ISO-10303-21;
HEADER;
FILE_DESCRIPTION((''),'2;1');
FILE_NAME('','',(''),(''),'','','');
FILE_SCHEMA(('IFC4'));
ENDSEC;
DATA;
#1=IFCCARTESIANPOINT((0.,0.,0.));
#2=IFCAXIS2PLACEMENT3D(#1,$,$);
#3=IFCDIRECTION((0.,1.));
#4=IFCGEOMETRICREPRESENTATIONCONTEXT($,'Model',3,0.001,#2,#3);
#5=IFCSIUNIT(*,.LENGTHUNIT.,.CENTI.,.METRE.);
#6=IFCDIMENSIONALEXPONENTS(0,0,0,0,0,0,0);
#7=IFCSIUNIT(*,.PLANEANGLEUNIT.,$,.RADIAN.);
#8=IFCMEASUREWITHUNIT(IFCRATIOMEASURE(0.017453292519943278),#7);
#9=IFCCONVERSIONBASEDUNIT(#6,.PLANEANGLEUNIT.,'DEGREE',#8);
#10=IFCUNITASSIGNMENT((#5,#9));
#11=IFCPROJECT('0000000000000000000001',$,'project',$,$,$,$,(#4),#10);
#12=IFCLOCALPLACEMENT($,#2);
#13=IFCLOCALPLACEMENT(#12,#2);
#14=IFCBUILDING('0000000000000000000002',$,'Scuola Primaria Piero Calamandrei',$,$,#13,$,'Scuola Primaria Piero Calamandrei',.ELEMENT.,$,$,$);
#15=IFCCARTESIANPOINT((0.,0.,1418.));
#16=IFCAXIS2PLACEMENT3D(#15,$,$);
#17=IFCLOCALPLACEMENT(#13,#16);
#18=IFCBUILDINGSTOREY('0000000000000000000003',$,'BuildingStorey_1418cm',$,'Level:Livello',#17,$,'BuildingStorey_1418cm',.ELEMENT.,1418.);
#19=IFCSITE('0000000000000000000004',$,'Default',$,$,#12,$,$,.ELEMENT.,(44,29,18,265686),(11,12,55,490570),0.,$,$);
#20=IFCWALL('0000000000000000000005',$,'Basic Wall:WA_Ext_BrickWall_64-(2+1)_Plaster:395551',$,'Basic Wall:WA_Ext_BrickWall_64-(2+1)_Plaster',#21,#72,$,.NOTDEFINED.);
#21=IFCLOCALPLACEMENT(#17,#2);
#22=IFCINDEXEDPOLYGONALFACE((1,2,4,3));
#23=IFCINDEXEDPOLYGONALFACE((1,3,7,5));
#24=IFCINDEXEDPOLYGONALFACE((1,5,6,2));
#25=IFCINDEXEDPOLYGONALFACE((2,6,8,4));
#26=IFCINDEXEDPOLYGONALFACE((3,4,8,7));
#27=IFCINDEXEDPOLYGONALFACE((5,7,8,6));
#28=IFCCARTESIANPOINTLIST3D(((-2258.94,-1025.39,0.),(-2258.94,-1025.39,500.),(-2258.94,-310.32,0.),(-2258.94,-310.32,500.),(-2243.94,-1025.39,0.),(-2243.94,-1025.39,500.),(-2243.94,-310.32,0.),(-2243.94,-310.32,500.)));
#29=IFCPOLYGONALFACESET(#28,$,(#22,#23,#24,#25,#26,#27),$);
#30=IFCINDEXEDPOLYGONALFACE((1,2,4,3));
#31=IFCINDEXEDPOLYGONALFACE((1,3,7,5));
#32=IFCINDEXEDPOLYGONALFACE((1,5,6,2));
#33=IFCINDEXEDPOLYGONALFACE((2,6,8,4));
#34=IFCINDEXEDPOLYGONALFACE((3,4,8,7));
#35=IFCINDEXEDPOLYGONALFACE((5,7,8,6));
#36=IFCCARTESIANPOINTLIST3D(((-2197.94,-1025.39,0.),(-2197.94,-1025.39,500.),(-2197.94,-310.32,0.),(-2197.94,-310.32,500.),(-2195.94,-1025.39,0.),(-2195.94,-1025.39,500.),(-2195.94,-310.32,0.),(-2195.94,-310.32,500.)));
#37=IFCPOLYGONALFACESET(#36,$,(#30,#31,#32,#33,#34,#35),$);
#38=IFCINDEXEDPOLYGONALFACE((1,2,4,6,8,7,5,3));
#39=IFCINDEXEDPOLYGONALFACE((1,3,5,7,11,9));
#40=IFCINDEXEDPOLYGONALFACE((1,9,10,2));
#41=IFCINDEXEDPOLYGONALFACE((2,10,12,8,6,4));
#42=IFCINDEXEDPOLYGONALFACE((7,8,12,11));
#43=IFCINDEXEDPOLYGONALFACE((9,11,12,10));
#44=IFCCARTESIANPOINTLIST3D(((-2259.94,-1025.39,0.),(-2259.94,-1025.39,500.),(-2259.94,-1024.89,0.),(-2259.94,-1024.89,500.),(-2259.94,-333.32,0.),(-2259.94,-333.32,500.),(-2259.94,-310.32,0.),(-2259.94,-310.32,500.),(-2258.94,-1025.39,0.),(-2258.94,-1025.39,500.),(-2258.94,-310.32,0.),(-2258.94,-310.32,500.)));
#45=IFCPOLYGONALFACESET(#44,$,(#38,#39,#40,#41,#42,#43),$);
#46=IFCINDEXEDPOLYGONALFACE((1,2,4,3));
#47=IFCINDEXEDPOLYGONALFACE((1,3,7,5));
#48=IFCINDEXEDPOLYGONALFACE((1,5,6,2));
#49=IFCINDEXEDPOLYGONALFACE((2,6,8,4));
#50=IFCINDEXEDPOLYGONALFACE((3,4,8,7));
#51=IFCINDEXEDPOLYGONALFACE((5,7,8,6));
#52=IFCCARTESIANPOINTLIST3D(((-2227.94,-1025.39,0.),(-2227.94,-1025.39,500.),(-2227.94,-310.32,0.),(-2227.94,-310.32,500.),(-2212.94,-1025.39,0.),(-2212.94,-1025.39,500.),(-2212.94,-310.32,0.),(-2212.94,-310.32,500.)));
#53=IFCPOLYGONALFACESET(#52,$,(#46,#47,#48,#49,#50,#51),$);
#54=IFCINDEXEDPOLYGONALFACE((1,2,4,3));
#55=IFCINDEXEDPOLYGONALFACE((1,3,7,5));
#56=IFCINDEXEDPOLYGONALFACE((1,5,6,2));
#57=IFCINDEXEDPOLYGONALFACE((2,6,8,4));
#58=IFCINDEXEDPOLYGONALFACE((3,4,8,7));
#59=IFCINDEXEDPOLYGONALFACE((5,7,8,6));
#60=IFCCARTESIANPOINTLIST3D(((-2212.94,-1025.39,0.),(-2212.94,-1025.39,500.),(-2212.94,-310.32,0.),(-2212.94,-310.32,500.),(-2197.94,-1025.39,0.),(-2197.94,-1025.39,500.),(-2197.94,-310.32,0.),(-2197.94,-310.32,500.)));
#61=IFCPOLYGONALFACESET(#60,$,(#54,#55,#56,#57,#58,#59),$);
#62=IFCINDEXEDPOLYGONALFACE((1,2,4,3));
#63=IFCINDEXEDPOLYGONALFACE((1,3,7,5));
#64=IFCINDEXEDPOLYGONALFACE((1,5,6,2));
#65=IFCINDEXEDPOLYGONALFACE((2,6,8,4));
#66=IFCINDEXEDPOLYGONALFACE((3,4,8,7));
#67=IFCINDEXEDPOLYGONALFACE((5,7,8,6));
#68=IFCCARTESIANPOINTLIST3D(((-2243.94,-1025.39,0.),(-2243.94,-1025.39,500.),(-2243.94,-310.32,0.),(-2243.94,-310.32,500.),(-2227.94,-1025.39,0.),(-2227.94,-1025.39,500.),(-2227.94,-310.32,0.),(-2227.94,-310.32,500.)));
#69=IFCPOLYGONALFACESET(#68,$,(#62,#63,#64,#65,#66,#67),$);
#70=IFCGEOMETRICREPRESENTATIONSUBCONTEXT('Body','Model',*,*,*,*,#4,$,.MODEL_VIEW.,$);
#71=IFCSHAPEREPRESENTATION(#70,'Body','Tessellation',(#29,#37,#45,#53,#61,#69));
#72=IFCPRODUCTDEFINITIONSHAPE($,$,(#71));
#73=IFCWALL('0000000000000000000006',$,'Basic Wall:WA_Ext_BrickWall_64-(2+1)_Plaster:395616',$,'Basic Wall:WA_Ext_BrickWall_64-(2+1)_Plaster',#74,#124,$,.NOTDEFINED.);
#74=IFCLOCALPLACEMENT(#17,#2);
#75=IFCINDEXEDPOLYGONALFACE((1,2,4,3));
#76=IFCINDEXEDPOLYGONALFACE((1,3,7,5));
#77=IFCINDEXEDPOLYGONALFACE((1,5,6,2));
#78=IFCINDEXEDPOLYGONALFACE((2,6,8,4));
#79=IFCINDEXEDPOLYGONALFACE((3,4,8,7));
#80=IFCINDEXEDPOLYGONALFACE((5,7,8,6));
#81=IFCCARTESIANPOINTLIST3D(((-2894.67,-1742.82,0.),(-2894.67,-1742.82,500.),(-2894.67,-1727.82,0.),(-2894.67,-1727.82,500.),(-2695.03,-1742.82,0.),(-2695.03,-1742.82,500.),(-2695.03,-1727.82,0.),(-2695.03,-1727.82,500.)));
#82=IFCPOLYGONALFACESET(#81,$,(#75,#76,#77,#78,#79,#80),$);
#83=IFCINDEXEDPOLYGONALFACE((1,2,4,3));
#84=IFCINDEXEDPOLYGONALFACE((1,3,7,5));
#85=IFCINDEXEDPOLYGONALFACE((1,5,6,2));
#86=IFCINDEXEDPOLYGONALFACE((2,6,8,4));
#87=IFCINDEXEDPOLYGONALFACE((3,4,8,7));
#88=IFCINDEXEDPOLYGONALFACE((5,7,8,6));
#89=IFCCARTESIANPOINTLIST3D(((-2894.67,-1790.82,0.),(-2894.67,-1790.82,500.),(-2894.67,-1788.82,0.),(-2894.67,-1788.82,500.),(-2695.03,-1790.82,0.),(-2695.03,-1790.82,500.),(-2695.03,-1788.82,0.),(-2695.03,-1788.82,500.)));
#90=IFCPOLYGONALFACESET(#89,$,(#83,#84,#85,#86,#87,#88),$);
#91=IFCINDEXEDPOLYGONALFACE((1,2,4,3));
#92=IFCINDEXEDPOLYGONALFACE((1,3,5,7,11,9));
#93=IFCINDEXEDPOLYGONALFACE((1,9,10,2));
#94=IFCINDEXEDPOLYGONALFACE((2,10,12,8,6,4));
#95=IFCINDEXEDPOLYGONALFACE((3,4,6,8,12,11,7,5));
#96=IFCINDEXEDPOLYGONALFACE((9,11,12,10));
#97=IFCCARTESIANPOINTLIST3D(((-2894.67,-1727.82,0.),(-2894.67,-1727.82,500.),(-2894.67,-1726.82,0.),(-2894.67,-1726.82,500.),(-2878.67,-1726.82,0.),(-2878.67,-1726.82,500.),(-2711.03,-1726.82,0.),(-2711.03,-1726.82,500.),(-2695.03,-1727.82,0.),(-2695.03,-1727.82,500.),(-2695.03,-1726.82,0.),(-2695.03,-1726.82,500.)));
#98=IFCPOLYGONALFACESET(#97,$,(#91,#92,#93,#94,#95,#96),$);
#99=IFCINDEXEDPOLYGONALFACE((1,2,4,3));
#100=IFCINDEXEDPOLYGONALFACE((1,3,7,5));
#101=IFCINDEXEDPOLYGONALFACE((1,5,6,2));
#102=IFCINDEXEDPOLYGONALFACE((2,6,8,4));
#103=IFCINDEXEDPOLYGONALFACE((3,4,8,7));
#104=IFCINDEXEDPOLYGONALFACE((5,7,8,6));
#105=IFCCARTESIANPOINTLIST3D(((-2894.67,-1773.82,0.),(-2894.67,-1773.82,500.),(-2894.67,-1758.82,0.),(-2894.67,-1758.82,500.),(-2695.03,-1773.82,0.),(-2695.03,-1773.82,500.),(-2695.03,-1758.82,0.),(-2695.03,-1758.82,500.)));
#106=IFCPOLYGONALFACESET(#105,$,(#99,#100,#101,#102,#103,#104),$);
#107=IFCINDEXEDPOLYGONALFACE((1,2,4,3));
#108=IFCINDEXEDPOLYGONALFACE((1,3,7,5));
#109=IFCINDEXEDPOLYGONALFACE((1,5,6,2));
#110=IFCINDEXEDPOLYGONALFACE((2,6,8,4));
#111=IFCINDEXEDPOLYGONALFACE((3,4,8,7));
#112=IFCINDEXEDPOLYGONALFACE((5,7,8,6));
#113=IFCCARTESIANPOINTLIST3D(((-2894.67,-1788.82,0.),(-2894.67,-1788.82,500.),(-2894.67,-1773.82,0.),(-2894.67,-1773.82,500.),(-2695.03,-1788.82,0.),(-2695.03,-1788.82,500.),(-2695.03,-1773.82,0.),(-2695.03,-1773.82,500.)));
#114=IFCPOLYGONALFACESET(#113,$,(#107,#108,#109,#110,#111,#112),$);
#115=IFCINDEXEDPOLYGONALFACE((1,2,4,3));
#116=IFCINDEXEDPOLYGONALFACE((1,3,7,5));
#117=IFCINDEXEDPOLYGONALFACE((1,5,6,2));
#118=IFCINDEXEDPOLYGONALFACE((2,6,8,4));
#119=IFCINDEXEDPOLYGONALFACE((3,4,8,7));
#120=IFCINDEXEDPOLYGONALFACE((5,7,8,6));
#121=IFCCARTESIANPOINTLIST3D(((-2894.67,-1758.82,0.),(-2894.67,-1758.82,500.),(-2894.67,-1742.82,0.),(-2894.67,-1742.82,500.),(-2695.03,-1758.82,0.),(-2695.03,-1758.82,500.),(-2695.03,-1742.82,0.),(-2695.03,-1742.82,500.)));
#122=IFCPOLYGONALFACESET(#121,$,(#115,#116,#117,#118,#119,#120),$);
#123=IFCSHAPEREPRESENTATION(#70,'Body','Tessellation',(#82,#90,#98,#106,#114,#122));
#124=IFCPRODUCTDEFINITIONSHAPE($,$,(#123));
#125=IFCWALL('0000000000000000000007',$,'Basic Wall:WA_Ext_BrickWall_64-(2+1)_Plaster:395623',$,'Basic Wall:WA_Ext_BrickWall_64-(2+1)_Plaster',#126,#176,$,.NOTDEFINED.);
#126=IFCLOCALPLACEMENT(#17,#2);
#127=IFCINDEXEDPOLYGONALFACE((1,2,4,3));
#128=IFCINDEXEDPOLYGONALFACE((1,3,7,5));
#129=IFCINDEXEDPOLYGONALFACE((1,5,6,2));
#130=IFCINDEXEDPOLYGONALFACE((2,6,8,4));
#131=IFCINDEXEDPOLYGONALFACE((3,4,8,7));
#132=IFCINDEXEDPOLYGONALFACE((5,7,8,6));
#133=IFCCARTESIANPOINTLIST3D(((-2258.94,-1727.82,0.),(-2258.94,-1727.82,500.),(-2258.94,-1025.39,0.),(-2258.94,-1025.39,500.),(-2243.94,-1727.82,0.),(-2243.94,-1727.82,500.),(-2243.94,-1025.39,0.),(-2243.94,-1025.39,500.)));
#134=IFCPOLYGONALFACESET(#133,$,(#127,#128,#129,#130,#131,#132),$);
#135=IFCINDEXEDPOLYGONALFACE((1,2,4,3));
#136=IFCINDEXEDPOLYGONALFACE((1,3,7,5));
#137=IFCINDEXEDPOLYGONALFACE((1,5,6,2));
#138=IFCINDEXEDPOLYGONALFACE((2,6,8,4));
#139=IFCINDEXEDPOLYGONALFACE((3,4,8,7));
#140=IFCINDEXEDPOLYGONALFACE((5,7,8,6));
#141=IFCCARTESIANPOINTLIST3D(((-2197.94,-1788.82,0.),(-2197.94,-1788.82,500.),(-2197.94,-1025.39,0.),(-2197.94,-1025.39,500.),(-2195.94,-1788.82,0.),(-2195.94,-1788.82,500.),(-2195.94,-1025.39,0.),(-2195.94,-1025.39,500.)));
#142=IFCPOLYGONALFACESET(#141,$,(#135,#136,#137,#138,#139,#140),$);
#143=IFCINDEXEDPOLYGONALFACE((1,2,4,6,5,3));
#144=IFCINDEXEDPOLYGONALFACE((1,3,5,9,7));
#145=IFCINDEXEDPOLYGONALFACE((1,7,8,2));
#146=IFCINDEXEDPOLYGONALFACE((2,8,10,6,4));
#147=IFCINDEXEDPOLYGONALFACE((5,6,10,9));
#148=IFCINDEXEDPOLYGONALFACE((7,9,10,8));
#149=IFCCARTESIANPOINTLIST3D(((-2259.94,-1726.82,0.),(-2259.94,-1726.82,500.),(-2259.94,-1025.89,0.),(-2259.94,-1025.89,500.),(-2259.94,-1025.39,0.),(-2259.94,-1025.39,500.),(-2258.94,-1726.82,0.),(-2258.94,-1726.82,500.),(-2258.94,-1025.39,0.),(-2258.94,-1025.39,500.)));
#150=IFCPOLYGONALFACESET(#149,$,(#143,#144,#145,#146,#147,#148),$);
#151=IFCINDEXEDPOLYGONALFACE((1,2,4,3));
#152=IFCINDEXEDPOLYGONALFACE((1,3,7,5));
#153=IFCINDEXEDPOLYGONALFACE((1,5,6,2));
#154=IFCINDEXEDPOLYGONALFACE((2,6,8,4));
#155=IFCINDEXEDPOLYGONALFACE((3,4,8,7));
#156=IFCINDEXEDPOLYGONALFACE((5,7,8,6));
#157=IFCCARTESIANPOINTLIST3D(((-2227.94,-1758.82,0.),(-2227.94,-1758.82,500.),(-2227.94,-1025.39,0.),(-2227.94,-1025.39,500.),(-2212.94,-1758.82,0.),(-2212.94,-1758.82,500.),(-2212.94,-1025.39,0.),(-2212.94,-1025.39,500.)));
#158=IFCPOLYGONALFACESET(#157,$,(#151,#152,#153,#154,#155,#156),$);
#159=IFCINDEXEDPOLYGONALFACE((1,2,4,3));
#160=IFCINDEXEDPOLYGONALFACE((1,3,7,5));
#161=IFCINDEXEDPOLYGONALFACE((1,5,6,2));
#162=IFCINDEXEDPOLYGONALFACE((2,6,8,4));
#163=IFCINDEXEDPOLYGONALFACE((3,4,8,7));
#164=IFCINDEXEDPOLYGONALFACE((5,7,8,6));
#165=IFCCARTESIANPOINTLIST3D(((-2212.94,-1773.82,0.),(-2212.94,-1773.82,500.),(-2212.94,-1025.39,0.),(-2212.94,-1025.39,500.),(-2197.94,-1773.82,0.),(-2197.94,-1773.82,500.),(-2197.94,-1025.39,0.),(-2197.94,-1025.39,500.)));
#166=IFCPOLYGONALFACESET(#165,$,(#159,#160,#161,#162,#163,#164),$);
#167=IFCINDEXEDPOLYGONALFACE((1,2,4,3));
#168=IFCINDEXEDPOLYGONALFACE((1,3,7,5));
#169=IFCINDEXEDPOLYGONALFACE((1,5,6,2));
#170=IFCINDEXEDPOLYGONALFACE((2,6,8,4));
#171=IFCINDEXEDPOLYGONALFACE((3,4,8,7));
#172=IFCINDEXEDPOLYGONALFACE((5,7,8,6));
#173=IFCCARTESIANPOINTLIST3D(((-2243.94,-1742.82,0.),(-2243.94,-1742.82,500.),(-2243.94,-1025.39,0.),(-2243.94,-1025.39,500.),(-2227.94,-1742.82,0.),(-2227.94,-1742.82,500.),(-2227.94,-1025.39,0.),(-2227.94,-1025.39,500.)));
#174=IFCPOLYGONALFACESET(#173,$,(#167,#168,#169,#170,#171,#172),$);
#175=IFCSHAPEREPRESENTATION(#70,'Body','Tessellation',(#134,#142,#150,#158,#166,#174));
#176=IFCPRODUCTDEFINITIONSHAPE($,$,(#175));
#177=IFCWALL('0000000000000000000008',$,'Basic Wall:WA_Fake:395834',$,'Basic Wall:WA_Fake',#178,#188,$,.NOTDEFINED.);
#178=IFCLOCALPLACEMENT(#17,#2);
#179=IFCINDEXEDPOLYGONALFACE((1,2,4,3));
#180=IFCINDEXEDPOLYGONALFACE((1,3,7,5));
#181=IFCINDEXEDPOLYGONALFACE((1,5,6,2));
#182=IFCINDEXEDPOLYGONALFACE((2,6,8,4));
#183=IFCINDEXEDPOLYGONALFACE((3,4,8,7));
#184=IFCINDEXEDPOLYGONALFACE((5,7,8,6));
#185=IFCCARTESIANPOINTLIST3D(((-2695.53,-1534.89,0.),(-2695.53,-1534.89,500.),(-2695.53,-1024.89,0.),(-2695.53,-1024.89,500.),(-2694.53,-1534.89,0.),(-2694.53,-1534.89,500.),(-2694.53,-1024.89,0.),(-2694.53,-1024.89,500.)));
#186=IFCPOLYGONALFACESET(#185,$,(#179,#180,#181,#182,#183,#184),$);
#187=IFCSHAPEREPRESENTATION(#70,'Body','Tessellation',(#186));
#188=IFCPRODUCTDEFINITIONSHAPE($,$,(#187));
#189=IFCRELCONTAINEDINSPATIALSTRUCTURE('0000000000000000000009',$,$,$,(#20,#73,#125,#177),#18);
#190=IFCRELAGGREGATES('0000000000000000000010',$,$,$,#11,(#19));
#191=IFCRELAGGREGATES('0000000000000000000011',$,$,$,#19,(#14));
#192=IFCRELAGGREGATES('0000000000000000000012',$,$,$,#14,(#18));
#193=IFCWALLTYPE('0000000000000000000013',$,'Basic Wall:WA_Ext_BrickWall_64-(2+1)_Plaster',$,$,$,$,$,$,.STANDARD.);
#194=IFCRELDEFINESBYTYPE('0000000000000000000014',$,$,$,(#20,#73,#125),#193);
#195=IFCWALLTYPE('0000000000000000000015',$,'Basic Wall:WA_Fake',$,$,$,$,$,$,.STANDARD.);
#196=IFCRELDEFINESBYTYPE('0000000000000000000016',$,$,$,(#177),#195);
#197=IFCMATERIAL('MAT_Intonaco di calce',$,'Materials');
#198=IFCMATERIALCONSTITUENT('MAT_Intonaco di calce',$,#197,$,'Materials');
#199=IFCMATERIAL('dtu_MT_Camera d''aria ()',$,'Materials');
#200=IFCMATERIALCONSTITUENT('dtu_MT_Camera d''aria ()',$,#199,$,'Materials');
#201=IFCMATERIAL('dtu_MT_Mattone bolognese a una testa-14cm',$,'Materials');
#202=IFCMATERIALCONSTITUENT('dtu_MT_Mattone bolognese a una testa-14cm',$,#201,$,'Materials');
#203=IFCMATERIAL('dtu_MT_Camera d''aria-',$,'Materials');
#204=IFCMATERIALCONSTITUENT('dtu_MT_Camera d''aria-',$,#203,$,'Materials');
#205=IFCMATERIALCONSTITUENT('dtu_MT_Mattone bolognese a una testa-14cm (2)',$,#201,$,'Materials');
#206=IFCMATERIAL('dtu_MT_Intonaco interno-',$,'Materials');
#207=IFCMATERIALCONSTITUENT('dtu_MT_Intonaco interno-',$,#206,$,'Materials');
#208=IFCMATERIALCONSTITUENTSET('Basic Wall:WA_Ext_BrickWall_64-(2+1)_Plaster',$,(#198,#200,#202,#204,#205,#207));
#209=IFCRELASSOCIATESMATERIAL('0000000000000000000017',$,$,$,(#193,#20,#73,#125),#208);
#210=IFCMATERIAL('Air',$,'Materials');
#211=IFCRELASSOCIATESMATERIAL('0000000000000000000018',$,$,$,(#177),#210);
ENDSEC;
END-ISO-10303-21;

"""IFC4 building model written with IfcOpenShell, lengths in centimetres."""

from ifc_helpers import new_model, entity, si_unit, converted_unit, direction, frame, origin, place, context, subcontext, project, spatial, indexed_curve, outline, extrude, material, constituent, constituent_set, type_object, element, save


model = new_model("IFC4")

# Units and contexts
model_context = context("Model", 3, precision=0.001, world=origin(), true_north=direction((0.0, 1.0)))
body_context = subcontext(model_context, "Body", "Model", "MODEL_VIEW")
ifc_project = project(units=[si_unit("LENGTHUNIT", "METRE", prefix="CENTI"), converted_unit("PLANEANGLEUNIT", "DEGREE", entity("IfcRatioMeasure", 0.017453292519943278), si_unit("PLANEANGLEUNIT", "RADIAN"), dimensions=[0, 0, 0, 0, 0, 0, 0])], contexts=[model_context])

# Site, building, storey
site_placement = place(None, origin())
site = spatial("IfcSite", under=ifc_project, at=site_placement, Name="Default", CompositionType="ELEMENT", RefLatitude=(44, 29, 18, 265686), RefLongitude=(11, 12, 55, 490570), RefElevation=0.0)
building_placement = place(site_placement, origin())
building = spatial("IfcBuilding", under=site, at=building_placement, Name="Scuola Primaria Piero Calamandrei", LongName="Scuola Primaria Piero Calamandrei", CompositionType="ELEMENT")
storey_placement = place(building_placement, frame((0.0, 0.0, 1418.0)))
storey = spatial("IfcBuildingStorey", under=building, at=storey_placement, Name="BuildingStorey_1418cm", ObjectType="Level:Livello", LongName="BuildingStorey_1418cm", CompositionType="ELEMENT", Elevation=1418.0)

# Shared definitions
ifc_material_1 = material(Name="dtu_MT_Intonaco interno-", Category="Materials")

# Walls
ifc_material_2 = material(Name="MAT_Intonaco di calce", Category="Materials")
ifc_constituent_1 = constituent(ifc_material_2, Name="MAT_Intonaco di calce", Category="Materials")
ifc_material_3 = material(Name="dtu_MT_Camera d'aria ()", Category="Materials")
ifc_constituent_2 = constituent(ifc_material_3, Name="dtu_MT_Camera d'aria ()", Category="Materials")
ifc_material_4 = material(Name="dtu_MT_Mattone bolognese a una testa-14cm", Category="Materials")
ifc_constituent_3 = constituent(ifc_material_4, Name="dtu_MT_Mattone bolognese a una testa-14cm", Category="Materials")
ifc_material_5 = material(Name="dtu_MT_Camera d'aria-", Category="Materials")
ifc_constituent_4 = constituent(ifc_material_5, Name="dtu_MT_Camera d'aria-", Category="Materials")
ifc_constituent_5 = constituent(ifc_material_4, Name="dtu_MT_Mattone bolognese a una testa-14cm (2)", Category="Materials")
ifc_constituent_6 = constituent(ifc_material_1, Name="dtu_MT_Intonaco interno-", Category="Materials")
ifc_constituent_set_1 = constituent_set(constituents=[ifc_constituent_1, ifc_constituent_2, ifc_constituent_3, ifc_constituent_4, ifc_constituent_5, ifc_constituent_6], Name="Basic Wall:WA_Ext_BrickWall_64-(2+1)_Plaster")
wall_type_1 = type_object("IfcWallType", Name="Basic Wall:WA_Ext_BrickWall_64-(2+1)_Plaster", PredefinedType="STANDARD", material=ifc_constituent_set_1)
wall_1_placement = place(storey_placement, frame((-2227.94, -310.32, 0.0), z_axis=(0.0, 0.0, 1.0), x_axis=(0.0, -1.0, 0.0)))
element("IfcWall", 1, at=wall_1_placement, inside=storey, type_object=wall_type_1, material=ifc_constituent_set_1, Name="Basic Wall:WA_Ext_BrickWall_64-(2+1)_Plaster:395551", ObjectType="Basic Wall:WA_Ext_BrickWall_64-(2+1)_Plaster", PredefinedType="NOTDEFINED", context=body_context, shape_type="SweptSolid", body=[
    extrude(outline(indexed_curve([(-357.54, -7.5), (357.54, -7.5), (357.54, 7.5), (-357.54, 7.5), (-357.54, -7.5)], self_intersect=False)), frame((357.54, -23.5, 0.0)), (0.0, 0.0, 1.0), 500.0),
    extrude(outline(indexed_curve([(-1.0, -357.54), (1.0, -357.54), (1.0, 357.54), (-1.0, 357.54), (-1.0, -357.54)], self_intersect=False)), frame((357.54, 31.0, 0.0), z_axis=(0.0, 0.0, 1.0), x_axis=(0.0, -1.0, 0.0)), (0.0, 0.0, 1.0), 500.0),
    extrude(outline(indexed_curve([(-338.29, -0.33), (353.29, -0.33), (353.79, -0.33), (353.79, 0.67), (-361.29, 0.67), (-361.29, -0.33), (-338.29, -0.33)], self_intersect=False)), frame((361.29, -31.67, 0.0)), (0.0, 0.0, 1.0), 500.0),
    extrude(outline(indexed_curve([(-357.54, -7.5), (357.54, -7.5), (357.54, 7.5), (-357.54, 7.5), (-357.54, -7.5)], self_intersect=False)), frame((357.54, 7.5, 0.0)), (0.0, 0.0, 1.0), 500.0),
    extrude(outline(indexed_curve([(-357.54, -7.5), (357.54, -7.5), (357.54, 7.5), (-357.54, 7.5), (-357.54, -7.5)], self_intersect=False)), frame((357.54, 22.5, 0.0)), (0.0, 0.0, 1.0), 500.0),
    extrude(outline(indexed_curve([(-357.54, -8.0), (357.54, -8.0), (357.54, 8.0), (-357.54, 8.0), (-357.54, -8.0)], self_intersect=False)), frame((357.54, -8.0, 0.0)), (0.0, 0.0, 1.0), 500.0),
])
wall_2_placement = place(storey_placement, frame((-2695.03, -1758.82, 0.0), z_axis=(0.0, 0.0, 1.0), x_axis=(-1.0, 0.0, 0.0)))
element("IfcWall", 2, at=wall_2_placement, inside=storey, type_object=wall_type_1, material=ifc_constituent_set_1, Name="Basic Wall:WA_Ext_BrickWall_64-(2+1)_Plaster:395616", ObjectType="Basic Wall:WA_Ext_BrickWall_64-(2+1)_Plaster", PredefinedType="NOTDEFINED", context=body_context, shape_type="SweptSolid", body=[
    extrude(outline(indexed_curve([(-99.82, -7.5), (99.82, -7.5), (99.82, 7.5), (-99.82, 7.5), (-99.82, -7.5)], self_intersect=False)), frame((99.82, -23.5, 0.0)), (0.0, 0.0, 1.0), 500.0),
    extrude(outline(indexed_curve([(-1.0, -99.82), (1.0, -99.82), (1.0, 99.82), (-1.0, 99.82), (-1.0, -99.82)], self_intersect=False)), frame((99.82, 31.0, 0.0), z_axis=(0.0, 0.0, 1.0), x_axis=(0.0, -1.0, 0.0)), (0.0, 0.0, 1.0), 500.0),
    extrude(outline(indexed_curve([(-83.82, -0.33), (83.82, -0.33), (99.82, -0.33), (99.82, 0.67), (-99.82, 0.67), (-99.82, -0.33), (-83.82, -0.33)], self_intersect=False)), frame((99.82, -31.67, 0.0)), (0.0, 0.0, 1.0), 500.0),
    extrude(outline(indexed_curve([(-99.82, -7.5), (99.82, -7.5), (99.82, 7.5), (-99.82, 7.5), (-99.82, -7.5)], self_intersect=False)), frame((99.82, 7.5, 0.0)), (0.0, 0.0, 1.0), 500.0),
    extrude(outline(indexed_curve([(-99.82, -7.5), (99.82, -7.5), (99.82, 7.5), (-99.82, 7.5), (-99.82, -7.5)], self_intersect=False)), frame((99.82, 22.5, 0.0)), (0.0, 0.0, 1.0), 500.0),
    extrude(outline(indexed_curve([(-99.82, -8.0), (99.82, -8.0), (99.82, 8.0), (-99.82, 8.0), (-99.82, -8.0)], self_intersect=False)), frame((99.82, -8.0, 0.0)), (0.0, 0.0, 1.0), 500.0),
])

# Walls
wall_3_placement = place(storey_placement, frame((-2227.94, -1025.39, 0.0), z_axis=(0.0, 0.0, 1.0), x_axis=(0.0, -1.0, 0.0)))
element("IfcWall", 3, at=wall_3_placement, inside=storey, type_object=wall_type_1, material=ifc_constituent_set_1, Name="Basic Wall:WA_Ext_BrickWall_64-(2+1)_Plaster:395623", ObjectType="Basic Wall:WA_Ext_BrickWall_64-(2+1)_Plaster", PredefinedType="NOTDEFINED", context=body_context, shape_type="SweptSolid", body=[
    extrude(outline(indexed_curve([(-351.21, -7.5), (351.21, -7.5), (351.21, 7.5), (-351.21, 7.5), (-351.21, -7.5)], self_intersect=False)), frame((351.21, -23.5, 0.0)), (0.0, 0.0, 1.0), 500.0),
    extrude(outline(indexed_curve([(-1.0, -381.71), (1.0, -381.71), (1.0, 381.71), (-1.0, 381.71), (-1.0, -381.71)], self_intersect=False)), frame((381.71, 31.0, 0.0), z_axis=(0.0, 0.0, 1.0), x_axis=(0.0, -1.0, 0.0)), (0.0, 0.0, 1.0), 500.0),
    extrude(outline(indexed_curve([(-280.17, -0.4), (420.76, -0.4), (420.76, 0.6), (-280.67, 0.6), (-280.67, -0.4), (-280.17, -0.4)], self_intersect=False)), frame((280.67, -31.6, 0.0)), (0.0, 0.0, 1.0), 500.0),
    extrude(outline(indexed_curve([(-366.71, -7.5), (366.71, -7.5), (366.71, 7.5), (-366.71, 7.5), (-366.71, -7.5)], self_intersect=False)), frame((366.71, 7.5, 0.0)), (0.0, 0.0, 1.0), 500.0),
    extrude(outline(indexed_curve([(-374.21, -7.5), (374.21, -7.5), (374.21, 7.5), (-374.21, 7.5), (-374.21, -7.5)], self_intersect=False)), frame((374.21, 22.5, 0.0)), (0.0, 0.0, 1.0), 500.0),
    extrude(outline(indexed_curve([(-358.71, -8.0), (358.71, -8.0), (358.71, 8.0), (-358.71, 8.0), (-358.71, -8.0)], self_intersect=False)), frame((358.71, -8.0, 0.0)), (0.0, 0.0, 1.0), 500.0),
])
ifc_material_6 = material(Name="Air", Category="Materials")
wall_type_2 = type_object("IfcWallType", Name="Basic Wall:WA_Fake", PredefinedType="STANDARD")
wall_4_placement = place(storey_placement, frame((-2695.03, -1024.89, 0.0), z_axis=(0.0, 0.0, 1.0), x_axis=(0.0, -1.0, 0.0)))
element("IfcWall", 4, at=wall_4_placement, inside=storey, type_object=wall_type_2, material=ifc_material_6, Name="Basic Wall:WA_Fake:395834", ObjectType="Basic Wall:WA_Fake", PredefinedType="NOTDEFINED", context=body_context, shape_type="SweptSolid", body=[
    extrude(outline(indexed_curve([(510.0, 0.5), (0.0, 0.5), (0.0, -0.5), (510.0, -0.5), (510.0, 0.5)], self_intersect=False)), origin(), (0.0, 0.0, 1.0), 500.0),
])

save(model, "model.ifc")
